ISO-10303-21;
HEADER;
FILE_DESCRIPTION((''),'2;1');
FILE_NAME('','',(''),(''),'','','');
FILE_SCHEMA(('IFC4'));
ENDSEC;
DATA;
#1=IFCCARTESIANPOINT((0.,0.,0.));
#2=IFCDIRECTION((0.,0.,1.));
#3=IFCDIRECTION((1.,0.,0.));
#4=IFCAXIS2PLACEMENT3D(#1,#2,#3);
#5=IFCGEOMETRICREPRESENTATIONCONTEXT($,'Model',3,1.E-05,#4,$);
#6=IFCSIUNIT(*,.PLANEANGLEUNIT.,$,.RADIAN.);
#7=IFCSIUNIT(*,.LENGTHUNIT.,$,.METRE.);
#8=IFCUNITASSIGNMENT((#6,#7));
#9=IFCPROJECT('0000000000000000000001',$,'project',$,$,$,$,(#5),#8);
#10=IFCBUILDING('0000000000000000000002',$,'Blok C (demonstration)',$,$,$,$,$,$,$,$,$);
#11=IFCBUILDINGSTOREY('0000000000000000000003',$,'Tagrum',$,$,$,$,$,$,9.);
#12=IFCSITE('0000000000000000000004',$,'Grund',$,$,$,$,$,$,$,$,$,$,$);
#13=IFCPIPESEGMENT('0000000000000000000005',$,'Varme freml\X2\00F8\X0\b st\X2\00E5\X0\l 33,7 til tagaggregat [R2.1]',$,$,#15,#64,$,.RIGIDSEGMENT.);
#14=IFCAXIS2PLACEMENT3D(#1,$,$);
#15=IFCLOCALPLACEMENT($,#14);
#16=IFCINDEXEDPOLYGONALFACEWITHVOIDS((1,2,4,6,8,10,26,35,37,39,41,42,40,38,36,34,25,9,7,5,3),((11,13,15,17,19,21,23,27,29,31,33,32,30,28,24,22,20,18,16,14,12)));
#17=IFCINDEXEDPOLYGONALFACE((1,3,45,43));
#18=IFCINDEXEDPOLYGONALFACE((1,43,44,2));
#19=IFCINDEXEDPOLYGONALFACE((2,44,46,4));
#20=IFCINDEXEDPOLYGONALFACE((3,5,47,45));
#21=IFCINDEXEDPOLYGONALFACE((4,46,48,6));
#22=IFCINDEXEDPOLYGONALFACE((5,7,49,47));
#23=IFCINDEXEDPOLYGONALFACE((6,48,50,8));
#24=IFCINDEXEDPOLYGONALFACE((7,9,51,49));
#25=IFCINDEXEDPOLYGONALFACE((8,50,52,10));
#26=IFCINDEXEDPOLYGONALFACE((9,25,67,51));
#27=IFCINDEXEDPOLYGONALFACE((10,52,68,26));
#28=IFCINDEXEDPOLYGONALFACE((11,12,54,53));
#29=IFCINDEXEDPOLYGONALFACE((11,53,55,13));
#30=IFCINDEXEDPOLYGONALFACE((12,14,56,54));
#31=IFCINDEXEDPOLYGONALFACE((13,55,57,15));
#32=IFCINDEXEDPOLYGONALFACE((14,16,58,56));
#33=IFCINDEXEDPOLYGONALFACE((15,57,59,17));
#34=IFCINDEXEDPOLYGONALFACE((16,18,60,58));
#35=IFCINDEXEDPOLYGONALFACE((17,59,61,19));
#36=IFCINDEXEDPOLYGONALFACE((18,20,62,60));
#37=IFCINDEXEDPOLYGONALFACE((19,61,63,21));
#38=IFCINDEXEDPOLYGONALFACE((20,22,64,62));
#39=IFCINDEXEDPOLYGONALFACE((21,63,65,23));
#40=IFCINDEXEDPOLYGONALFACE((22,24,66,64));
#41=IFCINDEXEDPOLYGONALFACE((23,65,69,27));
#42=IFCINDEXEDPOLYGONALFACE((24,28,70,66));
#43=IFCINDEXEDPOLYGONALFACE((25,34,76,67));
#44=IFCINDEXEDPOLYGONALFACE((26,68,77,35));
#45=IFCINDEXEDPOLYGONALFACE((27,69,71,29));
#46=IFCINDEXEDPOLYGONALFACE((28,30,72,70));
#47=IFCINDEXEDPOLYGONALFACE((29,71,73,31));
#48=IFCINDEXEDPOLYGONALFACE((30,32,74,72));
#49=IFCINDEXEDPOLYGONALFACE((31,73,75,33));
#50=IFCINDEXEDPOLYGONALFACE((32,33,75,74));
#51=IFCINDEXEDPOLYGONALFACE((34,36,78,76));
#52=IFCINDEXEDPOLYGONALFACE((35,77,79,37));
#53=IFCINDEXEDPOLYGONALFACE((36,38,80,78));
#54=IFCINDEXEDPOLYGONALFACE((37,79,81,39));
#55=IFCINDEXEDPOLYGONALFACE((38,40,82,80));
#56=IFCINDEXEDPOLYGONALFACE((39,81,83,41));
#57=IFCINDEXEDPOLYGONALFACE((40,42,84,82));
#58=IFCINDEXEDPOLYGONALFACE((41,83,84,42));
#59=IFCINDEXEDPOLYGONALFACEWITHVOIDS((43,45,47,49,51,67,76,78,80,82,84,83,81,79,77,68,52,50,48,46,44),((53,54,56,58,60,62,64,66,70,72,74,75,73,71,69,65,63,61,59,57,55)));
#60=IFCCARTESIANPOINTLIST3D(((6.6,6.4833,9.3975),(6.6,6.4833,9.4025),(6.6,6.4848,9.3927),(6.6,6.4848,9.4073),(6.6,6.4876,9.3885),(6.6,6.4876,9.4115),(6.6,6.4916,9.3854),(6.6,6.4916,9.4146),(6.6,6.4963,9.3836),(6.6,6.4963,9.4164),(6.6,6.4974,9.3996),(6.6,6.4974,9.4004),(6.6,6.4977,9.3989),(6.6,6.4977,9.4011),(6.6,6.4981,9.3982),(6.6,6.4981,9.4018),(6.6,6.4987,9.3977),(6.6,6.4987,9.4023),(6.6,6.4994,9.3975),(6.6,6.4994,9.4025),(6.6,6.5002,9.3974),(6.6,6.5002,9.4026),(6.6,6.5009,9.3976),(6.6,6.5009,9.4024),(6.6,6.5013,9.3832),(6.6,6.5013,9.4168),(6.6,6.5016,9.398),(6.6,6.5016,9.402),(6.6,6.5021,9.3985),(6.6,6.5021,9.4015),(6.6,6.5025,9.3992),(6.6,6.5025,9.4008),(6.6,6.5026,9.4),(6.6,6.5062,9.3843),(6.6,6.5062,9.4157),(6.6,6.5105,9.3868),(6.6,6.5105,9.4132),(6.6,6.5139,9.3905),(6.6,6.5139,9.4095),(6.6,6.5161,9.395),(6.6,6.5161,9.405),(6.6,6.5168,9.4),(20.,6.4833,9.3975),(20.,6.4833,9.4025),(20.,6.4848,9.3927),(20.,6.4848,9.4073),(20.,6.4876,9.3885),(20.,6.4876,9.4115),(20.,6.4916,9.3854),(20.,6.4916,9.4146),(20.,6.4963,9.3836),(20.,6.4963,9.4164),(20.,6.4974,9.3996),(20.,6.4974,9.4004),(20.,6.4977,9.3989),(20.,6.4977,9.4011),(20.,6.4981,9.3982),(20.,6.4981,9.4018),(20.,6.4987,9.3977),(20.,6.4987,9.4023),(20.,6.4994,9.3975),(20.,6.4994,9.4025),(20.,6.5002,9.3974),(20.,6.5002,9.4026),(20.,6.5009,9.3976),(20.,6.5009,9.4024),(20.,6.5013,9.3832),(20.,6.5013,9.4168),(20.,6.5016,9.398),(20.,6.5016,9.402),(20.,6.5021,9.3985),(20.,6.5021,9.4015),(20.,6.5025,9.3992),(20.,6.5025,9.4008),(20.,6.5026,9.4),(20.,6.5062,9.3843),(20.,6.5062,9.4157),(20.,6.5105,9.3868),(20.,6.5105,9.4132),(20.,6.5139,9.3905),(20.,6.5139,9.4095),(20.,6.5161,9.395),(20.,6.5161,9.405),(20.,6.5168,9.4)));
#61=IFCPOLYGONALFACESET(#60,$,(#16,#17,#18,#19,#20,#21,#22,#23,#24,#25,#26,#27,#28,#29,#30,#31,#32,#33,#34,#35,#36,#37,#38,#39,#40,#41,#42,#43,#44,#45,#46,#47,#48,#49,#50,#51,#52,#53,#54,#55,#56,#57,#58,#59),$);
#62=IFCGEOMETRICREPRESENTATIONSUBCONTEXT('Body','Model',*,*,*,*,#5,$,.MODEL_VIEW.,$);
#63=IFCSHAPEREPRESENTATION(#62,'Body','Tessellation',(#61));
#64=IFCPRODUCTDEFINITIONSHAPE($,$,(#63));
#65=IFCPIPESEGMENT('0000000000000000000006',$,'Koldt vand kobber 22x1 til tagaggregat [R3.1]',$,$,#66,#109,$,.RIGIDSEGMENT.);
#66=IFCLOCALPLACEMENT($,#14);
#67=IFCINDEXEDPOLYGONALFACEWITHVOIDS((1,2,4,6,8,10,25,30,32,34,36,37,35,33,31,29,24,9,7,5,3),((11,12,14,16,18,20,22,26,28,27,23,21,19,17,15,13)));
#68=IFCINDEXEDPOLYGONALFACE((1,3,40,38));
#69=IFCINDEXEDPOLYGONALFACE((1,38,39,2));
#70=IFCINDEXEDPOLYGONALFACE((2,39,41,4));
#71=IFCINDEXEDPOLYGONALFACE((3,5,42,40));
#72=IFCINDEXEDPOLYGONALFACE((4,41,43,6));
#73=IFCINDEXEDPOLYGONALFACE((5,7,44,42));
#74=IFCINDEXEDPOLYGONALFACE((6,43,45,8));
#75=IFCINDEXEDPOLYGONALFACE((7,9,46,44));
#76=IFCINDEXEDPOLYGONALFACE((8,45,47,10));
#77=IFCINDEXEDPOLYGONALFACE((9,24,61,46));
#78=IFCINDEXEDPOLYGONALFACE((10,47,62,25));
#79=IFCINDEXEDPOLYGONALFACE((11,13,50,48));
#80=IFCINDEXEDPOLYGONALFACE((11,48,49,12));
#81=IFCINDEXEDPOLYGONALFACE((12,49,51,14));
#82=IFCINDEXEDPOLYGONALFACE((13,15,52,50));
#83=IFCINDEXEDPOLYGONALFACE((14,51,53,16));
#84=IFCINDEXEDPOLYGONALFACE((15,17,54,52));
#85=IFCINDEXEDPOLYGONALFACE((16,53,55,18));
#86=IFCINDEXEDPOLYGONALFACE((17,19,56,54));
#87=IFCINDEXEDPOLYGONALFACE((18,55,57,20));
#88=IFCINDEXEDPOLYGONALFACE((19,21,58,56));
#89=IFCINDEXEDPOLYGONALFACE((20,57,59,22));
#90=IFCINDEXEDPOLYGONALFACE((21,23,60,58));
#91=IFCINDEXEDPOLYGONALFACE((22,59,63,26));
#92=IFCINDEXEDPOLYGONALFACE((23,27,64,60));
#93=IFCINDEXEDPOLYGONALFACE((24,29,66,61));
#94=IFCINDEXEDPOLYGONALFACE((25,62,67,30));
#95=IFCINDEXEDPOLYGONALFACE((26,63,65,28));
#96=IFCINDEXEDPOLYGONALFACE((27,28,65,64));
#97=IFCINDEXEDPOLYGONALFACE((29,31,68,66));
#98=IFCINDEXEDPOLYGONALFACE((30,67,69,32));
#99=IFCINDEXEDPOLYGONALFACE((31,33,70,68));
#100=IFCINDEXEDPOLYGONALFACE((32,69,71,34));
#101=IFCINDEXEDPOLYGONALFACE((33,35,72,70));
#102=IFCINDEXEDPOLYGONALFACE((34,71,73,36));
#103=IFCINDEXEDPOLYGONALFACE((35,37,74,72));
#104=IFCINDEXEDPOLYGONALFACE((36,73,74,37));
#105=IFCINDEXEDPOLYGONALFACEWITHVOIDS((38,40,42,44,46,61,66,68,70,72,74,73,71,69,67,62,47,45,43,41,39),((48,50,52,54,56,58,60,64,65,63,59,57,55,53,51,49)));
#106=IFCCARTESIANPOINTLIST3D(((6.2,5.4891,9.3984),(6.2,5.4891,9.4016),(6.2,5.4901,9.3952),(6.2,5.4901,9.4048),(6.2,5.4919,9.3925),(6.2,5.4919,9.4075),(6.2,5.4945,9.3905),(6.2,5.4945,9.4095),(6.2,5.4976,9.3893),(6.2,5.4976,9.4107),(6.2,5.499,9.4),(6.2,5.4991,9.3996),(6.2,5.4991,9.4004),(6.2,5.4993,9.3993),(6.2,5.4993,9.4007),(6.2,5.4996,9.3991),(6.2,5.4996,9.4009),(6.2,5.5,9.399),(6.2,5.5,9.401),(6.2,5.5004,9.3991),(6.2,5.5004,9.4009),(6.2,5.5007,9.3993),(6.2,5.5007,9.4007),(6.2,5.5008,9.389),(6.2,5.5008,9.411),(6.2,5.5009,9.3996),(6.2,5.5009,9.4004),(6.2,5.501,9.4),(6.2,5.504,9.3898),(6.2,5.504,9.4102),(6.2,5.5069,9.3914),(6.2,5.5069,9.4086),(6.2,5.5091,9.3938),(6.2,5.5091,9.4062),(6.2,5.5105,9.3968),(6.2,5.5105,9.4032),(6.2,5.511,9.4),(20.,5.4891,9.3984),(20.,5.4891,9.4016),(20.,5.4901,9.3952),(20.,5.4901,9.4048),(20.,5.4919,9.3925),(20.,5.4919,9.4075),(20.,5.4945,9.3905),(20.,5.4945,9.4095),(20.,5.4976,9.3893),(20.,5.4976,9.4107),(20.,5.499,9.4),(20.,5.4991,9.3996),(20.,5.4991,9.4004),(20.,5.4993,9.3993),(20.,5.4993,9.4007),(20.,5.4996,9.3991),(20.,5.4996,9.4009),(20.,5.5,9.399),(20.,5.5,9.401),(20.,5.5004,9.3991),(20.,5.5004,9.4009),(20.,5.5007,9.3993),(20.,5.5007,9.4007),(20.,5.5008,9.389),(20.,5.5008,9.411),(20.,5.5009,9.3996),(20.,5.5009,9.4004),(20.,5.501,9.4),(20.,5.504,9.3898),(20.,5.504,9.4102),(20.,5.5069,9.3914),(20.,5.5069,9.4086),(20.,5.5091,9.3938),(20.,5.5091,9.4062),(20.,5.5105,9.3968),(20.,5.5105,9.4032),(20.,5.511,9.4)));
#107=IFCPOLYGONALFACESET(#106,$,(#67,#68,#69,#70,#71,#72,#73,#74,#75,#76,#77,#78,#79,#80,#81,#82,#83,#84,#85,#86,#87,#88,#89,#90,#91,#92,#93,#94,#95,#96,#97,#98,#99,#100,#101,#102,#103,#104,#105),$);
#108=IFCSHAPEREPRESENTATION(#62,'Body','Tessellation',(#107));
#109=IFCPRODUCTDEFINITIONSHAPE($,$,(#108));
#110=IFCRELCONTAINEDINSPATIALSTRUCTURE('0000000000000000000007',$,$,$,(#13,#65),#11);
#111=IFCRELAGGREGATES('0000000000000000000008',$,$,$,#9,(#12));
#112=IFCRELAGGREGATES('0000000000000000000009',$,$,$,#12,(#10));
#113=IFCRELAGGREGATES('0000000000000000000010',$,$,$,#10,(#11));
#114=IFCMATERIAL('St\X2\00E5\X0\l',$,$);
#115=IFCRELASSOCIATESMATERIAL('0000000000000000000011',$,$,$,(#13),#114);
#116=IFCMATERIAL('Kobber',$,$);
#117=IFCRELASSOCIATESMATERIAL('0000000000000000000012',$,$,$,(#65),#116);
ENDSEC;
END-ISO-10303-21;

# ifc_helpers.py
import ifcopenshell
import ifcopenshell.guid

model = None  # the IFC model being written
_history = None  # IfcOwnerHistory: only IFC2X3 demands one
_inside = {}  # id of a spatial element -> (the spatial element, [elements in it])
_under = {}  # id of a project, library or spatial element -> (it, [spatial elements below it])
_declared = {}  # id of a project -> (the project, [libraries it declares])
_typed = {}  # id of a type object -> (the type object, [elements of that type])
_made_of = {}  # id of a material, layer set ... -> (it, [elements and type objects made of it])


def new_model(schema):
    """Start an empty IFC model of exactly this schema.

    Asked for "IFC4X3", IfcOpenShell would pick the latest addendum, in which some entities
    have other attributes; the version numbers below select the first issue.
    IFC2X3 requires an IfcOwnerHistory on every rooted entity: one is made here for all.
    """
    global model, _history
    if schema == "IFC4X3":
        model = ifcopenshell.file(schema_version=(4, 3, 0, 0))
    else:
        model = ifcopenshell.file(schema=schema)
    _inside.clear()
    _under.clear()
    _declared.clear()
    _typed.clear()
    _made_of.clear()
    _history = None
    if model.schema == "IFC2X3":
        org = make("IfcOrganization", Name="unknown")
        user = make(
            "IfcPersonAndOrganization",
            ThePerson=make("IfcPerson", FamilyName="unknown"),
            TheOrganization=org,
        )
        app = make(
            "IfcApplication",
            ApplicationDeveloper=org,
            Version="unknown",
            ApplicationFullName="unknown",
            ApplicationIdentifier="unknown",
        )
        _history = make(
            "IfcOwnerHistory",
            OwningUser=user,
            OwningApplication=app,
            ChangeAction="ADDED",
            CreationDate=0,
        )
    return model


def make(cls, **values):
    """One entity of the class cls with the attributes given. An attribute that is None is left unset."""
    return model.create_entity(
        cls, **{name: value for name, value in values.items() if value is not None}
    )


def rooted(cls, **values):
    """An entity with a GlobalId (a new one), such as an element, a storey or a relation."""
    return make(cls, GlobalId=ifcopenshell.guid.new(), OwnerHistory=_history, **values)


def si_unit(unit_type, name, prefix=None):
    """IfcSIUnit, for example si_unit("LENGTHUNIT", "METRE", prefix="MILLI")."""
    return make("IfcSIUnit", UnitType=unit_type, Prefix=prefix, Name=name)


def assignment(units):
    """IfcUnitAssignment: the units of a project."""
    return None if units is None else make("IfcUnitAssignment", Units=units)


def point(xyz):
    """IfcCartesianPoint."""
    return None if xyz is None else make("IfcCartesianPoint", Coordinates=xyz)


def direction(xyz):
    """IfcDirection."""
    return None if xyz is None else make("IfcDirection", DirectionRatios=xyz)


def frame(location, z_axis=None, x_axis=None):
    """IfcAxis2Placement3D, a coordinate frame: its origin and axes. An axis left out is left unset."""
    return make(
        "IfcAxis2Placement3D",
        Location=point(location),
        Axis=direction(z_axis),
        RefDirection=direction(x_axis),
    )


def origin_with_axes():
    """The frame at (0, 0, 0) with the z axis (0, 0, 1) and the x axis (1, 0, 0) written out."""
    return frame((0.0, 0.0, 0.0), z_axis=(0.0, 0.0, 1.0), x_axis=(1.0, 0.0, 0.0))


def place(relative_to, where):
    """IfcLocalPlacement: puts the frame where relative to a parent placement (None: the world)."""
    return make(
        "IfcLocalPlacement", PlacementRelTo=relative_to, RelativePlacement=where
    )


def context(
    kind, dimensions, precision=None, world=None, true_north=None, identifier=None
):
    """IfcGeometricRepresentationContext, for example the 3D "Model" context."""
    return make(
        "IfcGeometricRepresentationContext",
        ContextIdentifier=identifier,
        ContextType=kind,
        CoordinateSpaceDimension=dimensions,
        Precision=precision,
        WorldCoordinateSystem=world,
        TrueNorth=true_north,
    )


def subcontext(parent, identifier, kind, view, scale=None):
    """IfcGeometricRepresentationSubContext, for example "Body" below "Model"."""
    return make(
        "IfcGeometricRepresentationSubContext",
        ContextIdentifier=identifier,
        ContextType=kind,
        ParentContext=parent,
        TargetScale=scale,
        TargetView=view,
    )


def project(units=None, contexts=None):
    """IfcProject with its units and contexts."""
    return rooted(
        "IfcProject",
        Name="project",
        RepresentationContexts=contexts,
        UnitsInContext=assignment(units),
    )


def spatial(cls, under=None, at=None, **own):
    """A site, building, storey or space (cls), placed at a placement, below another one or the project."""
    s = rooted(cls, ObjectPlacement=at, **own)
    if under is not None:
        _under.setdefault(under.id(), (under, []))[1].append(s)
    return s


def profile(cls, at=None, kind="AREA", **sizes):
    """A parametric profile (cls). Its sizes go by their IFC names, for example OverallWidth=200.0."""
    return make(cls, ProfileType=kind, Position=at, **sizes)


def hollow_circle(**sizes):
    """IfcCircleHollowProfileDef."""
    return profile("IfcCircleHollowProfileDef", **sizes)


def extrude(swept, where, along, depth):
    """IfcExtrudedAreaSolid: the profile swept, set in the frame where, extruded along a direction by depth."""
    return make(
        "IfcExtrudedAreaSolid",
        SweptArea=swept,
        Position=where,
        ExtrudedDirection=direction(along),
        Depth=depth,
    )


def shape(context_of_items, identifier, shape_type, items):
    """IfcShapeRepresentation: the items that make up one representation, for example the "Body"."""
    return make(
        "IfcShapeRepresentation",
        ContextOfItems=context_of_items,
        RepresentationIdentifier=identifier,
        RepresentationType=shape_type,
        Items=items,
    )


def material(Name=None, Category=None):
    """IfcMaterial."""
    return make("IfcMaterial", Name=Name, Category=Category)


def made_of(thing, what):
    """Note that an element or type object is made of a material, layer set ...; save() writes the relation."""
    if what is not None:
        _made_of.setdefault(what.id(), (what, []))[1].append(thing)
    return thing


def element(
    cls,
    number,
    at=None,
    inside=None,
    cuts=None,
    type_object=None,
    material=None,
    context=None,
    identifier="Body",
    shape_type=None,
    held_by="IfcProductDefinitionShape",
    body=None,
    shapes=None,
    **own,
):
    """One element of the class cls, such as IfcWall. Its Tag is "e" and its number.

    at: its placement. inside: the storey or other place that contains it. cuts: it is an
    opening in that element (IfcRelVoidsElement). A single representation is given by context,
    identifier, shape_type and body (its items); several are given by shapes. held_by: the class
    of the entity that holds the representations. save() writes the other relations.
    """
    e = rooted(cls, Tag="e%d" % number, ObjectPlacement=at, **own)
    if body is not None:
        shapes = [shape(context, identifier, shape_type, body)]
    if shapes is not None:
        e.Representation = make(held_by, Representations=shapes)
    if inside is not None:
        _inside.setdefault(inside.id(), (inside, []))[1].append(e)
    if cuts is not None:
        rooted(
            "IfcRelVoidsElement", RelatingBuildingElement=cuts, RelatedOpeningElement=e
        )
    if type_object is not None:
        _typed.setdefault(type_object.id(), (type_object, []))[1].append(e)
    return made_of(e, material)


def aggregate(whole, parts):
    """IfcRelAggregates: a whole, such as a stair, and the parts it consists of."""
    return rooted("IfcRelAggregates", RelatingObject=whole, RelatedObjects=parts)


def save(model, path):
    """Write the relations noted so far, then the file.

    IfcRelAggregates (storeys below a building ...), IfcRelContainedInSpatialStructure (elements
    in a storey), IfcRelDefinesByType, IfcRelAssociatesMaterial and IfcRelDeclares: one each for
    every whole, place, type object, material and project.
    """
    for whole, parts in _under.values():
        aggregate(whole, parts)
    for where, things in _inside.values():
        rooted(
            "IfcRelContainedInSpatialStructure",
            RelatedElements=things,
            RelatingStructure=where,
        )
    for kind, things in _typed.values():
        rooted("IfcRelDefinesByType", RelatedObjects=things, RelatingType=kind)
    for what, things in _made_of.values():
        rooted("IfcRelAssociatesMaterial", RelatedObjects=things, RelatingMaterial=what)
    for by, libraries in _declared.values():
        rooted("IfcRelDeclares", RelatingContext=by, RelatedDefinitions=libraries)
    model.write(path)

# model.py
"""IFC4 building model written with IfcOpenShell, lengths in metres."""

from ifc_helpers import new_model, si_unit, frame, origin_with_axes, place, context, subcontext, project, spatial, hollow_circle, extrude, material, element, save


model = new_model("IFC4")

# Units and contexts
model_context = context("Model", 3, precision=1e-05, world=origin_with_axes())
body_context = subcontext(model_context, "Body", "Model", "MODEL_VIEW")
ifc_project = project(units=[si_unit("PLANEANGLEUNIT", "RADIAN"), si_unit("LENGTHUNIT", "METRE")], contexts=[model_context])

# Site, building, storey
site = spatial("IfcSite", under=ifc_project, Name="Grund")
building = spatial("IfcBuilding", under=site, Name="Blok C (demonstration)")
storey = spatial("IfcBuildingStorey", under=building, Name="Tagrum", Elevation=9.0)

# Pipe segments
ifc_material_1 = material(Name="Kobber")
ifc_material_2 = material(Name="Stål")
pipe_segment_1_placement = place(None, origin_with_axes())
element("IfcPipeSegment", 1, at=pipe_segment_1_placement, inside=storey, material=ifc_material_2, Name="Varme fremløb stål 33,7 til tagaggregat [R2.1]", PredefinedType="RIGIDSEGMENT", context=body_context, shape_type="SweptSolid", body=[
    extrude(hollow_circle(Radius=0.0169, WallThickness=0.0143), frame((6.6, 6.5, 9.4), z_axis=(1.0, 0.0, 0.0), x_axis=(0.0, 1.0, 0.0)), (0.0, 0.0, 1.0), 13.4),
])
pipe_segment_2_placement = place(None, origin_with_axes())
element("IfcPipeSegment", 2, at=pipe_segment_2_placement, inside=storey, material=ifc_material_1, Name="Koldt vand kobber 22x1 til tagaggregat [R3.1]", PredefinedType="RIGIDSEGMENT", context=body_context, shape_type="SweptSolid", body=[
    extrude(hollow_circle(Radius=0.011, WallThickness=0.01), frame((6.2, 5.5, 9.4), z_axis=(1.0, 0.0, 0.0), x_axis=(0.0, 1.0, 0.0)), (0.0, 0.0, 1.0), 13.8),
])

save(model, "model.ifc")
